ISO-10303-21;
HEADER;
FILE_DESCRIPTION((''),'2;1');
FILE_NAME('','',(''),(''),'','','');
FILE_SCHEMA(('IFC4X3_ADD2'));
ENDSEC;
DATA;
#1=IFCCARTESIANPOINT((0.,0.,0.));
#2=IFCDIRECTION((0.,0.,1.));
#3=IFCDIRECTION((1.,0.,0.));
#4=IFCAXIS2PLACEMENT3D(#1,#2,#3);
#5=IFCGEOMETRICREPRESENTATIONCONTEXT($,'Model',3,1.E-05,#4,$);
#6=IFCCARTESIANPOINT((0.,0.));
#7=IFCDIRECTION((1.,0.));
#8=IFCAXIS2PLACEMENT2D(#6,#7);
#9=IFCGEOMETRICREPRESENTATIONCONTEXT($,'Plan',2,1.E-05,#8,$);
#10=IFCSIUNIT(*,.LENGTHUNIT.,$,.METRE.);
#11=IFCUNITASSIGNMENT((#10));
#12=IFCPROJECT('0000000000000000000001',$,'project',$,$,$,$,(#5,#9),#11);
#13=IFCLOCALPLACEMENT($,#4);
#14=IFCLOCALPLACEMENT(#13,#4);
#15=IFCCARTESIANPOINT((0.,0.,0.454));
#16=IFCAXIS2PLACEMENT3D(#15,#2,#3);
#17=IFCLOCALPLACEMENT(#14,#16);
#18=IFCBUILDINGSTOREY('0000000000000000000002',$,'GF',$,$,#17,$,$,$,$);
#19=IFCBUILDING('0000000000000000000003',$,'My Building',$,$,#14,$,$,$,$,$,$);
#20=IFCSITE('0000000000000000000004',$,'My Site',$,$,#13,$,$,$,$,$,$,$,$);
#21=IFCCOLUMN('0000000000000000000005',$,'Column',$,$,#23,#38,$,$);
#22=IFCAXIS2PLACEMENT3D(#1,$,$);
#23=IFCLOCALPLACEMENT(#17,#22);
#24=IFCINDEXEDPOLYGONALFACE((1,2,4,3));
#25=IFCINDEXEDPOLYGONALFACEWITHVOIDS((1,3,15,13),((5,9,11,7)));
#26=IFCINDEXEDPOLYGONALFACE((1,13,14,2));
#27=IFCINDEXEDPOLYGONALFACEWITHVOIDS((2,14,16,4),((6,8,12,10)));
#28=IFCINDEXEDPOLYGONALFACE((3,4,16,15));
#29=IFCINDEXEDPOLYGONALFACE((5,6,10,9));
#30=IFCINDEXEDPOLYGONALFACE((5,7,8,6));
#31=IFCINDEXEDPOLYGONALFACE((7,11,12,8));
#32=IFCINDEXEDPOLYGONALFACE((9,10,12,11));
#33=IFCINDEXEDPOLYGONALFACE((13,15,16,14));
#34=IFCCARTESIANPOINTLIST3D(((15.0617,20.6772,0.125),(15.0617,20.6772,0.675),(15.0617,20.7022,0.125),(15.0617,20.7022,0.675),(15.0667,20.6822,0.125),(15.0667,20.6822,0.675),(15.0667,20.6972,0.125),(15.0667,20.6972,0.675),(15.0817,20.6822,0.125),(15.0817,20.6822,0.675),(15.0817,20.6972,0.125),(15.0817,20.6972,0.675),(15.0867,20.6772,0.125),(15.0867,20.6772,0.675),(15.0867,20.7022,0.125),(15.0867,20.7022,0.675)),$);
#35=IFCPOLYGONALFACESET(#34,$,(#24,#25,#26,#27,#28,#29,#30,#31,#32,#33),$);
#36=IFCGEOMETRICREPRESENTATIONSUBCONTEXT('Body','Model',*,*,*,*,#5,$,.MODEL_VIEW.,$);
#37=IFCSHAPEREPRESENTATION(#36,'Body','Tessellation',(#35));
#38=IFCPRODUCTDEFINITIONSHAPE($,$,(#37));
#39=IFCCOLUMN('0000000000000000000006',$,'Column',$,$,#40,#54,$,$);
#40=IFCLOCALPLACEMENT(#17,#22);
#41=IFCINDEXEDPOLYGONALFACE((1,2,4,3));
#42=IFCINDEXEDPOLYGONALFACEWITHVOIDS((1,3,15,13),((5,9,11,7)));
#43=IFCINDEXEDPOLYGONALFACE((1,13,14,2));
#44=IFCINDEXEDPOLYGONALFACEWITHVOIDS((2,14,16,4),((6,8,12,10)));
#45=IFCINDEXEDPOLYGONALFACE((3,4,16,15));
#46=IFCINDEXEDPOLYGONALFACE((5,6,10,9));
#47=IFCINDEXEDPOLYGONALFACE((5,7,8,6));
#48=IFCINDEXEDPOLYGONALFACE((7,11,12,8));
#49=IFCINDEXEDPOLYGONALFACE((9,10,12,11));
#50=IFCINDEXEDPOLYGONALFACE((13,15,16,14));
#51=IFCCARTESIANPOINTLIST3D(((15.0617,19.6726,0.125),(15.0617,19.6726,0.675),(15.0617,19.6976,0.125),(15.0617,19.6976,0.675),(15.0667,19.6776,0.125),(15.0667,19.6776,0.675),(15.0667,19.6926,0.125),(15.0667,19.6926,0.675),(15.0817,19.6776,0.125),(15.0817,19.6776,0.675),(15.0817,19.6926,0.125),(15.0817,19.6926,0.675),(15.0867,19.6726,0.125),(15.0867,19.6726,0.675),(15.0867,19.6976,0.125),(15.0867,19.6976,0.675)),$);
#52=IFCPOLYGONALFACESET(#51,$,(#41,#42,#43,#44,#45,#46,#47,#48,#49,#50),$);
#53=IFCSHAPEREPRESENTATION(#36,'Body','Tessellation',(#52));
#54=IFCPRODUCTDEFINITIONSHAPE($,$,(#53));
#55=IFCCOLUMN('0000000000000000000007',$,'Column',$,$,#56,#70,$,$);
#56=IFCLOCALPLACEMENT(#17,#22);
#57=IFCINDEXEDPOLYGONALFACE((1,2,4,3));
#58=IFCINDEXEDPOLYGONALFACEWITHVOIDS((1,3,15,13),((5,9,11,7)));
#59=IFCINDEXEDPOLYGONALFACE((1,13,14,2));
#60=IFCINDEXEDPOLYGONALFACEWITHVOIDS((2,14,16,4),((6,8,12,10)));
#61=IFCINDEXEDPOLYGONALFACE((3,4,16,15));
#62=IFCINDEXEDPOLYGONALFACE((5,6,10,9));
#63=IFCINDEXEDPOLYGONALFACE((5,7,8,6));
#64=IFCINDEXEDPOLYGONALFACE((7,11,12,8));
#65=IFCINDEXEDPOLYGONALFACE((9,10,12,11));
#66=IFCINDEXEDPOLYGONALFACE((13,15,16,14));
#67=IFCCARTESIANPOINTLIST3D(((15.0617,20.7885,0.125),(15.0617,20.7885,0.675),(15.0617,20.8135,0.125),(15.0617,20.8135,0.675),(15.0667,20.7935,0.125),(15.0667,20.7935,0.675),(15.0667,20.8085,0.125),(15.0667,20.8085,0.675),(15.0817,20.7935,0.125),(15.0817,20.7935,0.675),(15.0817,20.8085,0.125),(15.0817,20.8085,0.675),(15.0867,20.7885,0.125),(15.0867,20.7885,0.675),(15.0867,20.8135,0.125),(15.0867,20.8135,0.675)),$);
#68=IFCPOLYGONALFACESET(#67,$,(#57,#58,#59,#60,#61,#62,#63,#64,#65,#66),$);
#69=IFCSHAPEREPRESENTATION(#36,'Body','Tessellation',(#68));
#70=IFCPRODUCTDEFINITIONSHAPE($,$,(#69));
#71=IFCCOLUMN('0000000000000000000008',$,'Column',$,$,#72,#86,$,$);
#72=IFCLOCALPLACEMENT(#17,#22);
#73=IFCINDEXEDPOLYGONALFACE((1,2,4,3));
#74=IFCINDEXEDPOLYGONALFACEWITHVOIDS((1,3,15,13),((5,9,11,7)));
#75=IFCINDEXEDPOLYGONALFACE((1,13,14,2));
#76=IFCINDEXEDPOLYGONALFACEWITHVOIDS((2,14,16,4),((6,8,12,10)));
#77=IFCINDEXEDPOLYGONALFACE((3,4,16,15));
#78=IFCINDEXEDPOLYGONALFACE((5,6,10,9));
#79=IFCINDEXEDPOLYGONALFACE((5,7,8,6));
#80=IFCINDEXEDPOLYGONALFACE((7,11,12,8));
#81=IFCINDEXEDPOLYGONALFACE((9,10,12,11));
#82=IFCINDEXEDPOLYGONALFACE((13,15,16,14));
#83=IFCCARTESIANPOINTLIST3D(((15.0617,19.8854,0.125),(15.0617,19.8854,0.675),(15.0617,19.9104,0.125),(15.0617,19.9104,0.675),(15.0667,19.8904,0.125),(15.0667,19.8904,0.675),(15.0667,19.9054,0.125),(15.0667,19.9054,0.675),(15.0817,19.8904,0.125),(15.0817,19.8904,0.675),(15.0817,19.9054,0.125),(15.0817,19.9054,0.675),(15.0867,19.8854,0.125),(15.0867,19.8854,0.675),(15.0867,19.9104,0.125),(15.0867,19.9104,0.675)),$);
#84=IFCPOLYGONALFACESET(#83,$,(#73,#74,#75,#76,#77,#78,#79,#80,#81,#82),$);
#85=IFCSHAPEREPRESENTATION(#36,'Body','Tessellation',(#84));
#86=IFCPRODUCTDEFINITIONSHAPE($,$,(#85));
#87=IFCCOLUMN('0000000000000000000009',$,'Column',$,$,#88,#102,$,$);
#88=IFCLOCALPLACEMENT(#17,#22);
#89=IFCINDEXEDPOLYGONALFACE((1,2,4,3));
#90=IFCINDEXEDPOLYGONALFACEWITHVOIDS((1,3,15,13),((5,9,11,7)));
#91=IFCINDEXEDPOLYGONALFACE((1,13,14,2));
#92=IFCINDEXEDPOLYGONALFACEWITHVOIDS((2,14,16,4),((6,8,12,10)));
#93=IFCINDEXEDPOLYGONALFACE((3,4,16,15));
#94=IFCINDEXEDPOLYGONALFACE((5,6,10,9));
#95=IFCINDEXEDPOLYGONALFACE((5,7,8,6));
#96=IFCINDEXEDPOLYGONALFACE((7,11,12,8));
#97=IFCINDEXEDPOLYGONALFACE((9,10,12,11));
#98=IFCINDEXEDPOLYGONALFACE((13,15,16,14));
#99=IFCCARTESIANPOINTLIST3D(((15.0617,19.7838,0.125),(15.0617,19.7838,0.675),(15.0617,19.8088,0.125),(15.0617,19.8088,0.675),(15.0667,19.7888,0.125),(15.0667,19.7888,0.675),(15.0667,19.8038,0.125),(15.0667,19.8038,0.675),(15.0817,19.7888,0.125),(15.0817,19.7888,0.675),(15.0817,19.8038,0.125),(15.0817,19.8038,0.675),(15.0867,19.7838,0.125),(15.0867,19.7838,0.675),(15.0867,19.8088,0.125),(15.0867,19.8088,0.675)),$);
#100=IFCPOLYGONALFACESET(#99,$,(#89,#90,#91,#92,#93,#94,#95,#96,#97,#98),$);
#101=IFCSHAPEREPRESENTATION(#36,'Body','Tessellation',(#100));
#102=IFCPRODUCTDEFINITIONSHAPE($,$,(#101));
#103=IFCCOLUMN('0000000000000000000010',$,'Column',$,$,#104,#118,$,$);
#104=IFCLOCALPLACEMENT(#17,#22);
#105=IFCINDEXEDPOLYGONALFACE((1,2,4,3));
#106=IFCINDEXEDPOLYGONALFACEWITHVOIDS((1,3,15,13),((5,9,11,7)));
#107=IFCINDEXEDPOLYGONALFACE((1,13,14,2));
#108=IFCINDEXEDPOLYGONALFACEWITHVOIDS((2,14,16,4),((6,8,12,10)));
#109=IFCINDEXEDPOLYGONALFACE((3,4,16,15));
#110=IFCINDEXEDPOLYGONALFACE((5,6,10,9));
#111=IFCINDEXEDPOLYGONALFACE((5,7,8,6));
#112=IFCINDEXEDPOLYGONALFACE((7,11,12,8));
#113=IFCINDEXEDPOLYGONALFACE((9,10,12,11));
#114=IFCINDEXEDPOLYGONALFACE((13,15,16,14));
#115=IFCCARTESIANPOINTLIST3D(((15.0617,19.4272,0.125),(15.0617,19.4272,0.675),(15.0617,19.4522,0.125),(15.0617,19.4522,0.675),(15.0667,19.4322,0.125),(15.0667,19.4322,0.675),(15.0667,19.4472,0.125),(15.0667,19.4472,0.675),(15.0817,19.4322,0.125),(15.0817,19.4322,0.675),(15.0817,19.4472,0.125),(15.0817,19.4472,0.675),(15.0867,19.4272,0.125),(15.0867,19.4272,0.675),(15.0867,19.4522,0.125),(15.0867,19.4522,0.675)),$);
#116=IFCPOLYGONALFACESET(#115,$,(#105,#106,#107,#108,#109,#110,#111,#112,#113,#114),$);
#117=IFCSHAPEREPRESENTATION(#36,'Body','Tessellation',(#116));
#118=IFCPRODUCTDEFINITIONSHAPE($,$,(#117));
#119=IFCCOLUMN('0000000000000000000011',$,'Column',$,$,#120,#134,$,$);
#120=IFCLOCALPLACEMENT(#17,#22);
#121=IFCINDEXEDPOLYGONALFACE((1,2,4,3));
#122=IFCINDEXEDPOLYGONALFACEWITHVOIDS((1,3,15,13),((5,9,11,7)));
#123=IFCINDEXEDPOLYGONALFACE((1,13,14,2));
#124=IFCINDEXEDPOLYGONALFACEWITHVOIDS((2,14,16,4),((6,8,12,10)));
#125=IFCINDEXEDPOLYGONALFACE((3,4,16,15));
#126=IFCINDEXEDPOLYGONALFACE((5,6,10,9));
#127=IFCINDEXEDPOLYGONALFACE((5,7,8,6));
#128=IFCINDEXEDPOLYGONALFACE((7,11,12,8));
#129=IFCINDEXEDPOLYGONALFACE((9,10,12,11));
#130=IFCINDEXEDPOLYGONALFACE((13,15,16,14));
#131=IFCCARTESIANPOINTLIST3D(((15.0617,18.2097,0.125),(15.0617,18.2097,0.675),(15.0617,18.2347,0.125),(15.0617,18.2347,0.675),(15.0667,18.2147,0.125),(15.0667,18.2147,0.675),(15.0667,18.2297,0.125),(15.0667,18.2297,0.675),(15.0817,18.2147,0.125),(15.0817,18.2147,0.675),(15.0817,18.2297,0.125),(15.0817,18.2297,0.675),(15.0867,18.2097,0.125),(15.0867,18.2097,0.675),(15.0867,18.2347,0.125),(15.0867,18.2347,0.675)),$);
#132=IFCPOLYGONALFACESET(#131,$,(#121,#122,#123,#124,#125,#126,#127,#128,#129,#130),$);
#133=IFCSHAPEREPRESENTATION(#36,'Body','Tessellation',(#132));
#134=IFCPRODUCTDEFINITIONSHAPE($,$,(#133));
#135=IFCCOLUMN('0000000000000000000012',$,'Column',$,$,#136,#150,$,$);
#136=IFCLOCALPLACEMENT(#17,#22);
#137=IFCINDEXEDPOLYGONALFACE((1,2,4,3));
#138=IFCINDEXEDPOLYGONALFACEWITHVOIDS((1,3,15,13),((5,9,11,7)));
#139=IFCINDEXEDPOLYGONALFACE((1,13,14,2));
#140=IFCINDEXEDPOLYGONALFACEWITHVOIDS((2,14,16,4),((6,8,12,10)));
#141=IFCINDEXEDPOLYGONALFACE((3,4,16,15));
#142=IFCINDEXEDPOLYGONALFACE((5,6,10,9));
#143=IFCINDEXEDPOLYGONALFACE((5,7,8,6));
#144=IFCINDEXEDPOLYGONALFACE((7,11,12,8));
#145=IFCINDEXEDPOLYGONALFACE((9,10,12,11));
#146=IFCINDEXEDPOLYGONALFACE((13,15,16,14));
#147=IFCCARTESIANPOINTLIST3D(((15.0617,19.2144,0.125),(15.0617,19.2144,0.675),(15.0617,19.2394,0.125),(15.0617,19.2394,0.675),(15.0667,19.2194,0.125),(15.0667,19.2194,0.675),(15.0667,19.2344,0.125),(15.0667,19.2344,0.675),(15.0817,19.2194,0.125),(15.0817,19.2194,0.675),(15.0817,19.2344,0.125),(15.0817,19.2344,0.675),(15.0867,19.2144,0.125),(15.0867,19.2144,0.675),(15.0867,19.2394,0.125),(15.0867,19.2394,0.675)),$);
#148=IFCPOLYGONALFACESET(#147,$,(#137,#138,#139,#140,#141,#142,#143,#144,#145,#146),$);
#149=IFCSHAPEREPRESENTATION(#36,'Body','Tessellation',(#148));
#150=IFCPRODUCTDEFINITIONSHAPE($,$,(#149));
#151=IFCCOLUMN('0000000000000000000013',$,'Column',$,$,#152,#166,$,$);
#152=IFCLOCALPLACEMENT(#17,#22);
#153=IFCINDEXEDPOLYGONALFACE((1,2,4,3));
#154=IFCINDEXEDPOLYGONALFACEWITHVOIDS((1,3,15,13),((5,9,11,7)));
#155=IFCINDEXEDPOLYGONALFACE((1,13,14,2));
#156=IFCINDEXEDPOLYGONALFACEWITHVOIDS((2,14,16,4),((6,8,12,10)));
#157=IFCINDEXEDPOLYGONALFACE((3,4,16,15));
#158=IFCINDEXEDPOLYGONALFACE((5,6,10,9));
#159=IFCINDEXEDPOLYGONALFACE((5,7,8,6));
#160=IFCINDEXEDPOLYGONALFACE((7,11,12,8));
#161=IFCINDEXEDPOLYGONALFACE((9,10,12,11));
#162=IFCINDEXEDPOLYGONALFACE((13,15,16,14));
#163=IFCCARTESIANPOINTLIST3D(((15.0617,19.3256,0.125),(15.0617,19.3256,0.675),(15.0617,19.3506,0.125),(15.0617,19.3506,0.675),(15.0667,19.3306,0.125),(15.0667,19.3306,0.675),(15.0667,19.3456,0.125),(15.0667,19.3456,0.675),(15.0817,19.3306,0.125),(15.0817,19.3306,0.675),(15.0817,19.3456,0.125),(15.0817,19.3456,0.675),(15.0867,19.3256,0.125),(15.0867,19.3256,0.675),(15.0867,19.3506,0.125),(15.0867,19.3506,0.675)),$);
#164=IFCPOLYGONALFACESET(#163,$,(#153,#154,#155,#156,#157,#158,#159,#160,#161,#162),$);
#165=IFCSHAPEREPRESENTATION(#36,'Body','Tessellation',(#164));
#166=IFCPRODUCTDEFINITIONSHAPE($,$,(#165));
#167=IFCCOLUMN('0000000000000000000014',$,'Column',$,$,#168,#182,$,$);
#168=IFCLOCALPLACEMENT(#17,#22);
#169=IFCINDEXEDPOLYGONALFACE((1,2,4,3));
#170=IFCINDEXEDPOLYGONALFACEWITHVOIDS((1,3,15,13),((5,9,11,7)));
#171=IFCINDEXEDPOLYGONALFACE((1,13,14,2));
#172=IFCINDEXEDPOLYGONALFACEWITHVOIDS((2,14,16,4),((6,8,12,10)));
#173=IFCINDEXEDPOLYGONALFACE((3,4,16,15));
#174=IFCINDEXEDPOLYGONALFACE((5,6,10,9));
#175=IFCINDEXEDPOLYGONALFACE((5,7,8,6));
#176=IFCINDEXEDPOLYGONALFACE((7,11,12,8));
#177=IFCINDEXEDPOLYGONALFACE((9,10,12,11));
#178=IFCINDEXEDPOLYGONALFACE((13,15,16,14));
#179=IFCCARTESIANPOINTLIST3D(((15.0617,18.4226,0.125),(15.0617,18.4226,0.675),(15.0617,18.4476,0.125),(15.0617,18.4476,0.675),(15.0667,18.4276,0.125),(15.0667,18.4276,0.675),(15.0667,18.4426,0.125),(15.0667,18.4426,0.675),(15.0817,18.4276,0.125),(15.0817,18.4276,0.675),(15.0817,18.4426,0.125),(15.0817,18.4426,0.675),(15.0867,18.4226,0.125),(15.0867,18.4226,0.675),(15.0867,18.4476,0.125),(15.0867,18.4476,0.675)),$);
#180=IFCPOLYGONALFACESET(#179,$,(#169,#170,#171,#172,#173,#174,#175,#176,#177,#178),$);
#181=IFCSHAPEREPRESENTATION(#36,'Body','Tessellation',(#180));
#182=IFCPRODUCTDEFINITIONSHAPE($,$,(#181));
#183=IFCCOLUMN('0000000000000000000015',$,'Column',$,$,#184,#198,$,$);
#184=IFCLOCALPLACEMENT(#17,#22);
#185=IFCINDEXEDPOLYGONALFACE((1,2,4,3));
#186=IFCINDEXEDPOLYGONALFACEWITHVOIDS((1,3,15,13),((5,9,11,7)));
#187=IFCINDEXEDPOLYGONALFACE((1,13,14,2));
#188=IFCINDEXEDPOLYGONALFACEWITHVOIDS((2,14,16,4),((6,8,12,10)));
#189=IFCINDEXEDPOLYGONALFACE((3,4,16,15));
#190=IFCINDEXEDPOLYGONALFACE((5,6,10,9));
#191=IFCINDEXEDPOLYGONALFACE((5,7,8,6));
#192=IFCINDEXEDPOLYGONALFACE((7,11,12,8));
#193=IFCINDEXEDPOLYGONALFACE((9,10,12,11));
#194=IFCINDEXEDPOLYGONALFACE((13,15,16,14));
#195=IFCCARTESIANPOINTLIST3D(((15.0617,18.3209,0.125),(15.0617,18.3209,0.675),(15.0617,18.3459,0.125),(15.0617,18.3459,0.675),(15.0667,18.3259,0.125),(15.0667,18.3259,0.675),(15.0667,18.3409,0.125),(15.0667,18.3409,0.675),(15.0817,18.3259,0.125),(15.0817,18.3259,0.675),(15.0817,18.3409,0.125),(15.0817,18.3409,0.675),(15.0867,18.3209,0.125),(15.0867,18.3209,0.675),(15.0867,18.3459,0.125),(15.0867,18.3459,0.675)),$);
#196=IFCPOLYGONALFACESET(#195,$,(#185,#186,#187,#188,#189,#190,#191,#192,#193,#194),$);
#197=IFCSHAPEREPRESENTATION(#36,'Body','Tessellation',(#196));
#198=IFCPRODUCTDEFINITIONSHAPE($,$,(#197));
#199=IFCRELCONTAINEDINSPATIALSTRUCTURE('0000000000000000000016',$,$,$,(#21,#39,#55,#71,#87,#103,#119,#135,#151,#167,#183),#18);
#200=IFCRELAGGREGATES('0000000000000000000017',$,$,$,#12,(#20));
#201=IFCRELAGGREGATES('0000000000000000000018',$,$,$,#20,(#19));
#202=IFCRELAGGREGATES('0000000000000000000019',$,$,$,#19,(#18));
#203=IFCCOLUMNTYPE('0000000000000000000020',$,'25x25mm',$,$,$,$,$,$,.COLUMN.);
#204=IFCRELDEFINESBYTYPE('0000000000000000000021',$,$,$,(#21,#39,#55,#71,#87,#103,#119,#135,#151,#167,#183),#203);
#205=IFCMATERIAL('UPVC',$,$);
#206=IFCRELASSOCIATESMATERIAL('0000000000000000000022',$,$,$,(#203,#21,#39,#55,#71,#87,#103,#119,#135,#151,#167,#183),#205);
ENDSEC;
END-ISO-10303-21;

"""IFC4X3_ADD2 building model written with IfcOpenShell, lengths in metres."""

from ifc_helpers import new_model, si_unit, frame, origin_with_axes, origin_2d_with_axis, place, context, subcontext, project, spatial, hollow_rectangle, extrude, material, material_profile, profile_set, profile_usage, type_object, element, save


model = new_model("IFC4X3_ADD2")

# Units and contexts
model_context = context("Model", 3, precision=1e-05, world=origin_with_axes())
plan_context = context("Plan", 2, precision=1e-05, world=origin_2d_with_axis())
body_context = subcontext(model_context, "Body", "Model", "MODEL_VIEW")
ifc_project = project(units=[si_unit("LENGTHUNIT", "METRE")], contexts=[model_context, plan_context])

# Site, building, storey
site_placement = place(None, origin_with_axes())
site = spatial("IfcSite", under=ifc_project, at=site_placement, Name="My Site")
building_placement = place(site_placement, origin_with_axes())
building = spatial("IfcBuilding", under=site, at=building_placement, Name="My Building")
storey_placement = place(building_placement, frame((0.0, 0.0, 0.454), z_axis=(0.0, 0.0, 1.0), x_axis=(1.0, 0.0, 0.0)))
storey = spatial("IfcBuildingStorey", under=building, at=storey_placement, Name="GF")

# Columns
ifc_material_1 = material(Name="UPVC")
ifc_material_profile_1 = material_profile(ifc_material_1, hollow_rectangle(XDim=0.025, YDim=0.025, WallThickness=0.005))
ifc_profile_set_1 = profile_set([ifc_material_profile_1])
ifc_profile_usage_1 = profile_usage(ifc_profile_set_1)
column_type_1 = type_object("IfcColumnType", Name="25x25mm", PredefinedType="COLUMN", material=ifc_profile_set_1)
column_1_placement = place(storey_placement, frame((15.0742, 20.6897, 0.125), z_axis=(0.0, 0.0, 1.0), x_axis=(0.0, -1.0, 0.0)))
element("IfcColumn", 1, at=column_1_placement, inside=storey, type_object=column_type_1, material=ifc_profile_usage_1, Name="Column", context=body_context, shape_type="SweptSolid", body=[
    extrude(hollow_rectangle(XDim=0.025, YDim=0.025, WallThickness=0.005), origin_with_axes(), (0.0, 0.0, 1.0), 0.55),
])
ifc_profile_usage_2 = profile_usage(ifc_profile_set_1)
column_2_placement = place(storey_placement, frame((15.0742, 19.6851, 0.125), z_axis=(0.0, 0.0, 1.0), x_axis=(0.0, -1.0, 0.0)))
element("IfcColumn", 2, at=column_2_placement, inside=storey, type_object=column_type_1, material=ifc_profile_usage_2, Name="Column", context=body_context, shape_type="SweptSolid", body=[
    extrude(hollow_rectangle(XDim=0.025, YDim=0.025, WallThickness=0.005), origin_with_axes(), (0.0, 0.0, 1.0), 0.55),
])
ifc_profile_usage_3 = profile_usage(ifc_profile_set_1)
column_3_placement = place(storey_placement, frame((15.0742, 20.801, 0.125), z_axis=(0.0, 0.0, 1.0), x_axis=(0.0, -1.0, 0.0)))
element("IfcColumn", 3, at=column_3_placement, inside=storey, type_object=column_type_1, material=ifc_profile_usage_3, Name="Column", context=body_context, shape_type="SweptSolid", body=[
    extrude(hollow_rectangle(XDim=0.025, YDim=0.025, WallThickness=0.005), origin_with_axes(), (0.0, 0.0, 1.0), 0.55),
])
ifc_profile_usage_4 = profile_usage(ifc_profile_set_1)
column_4_placement = place(storey_placement, frame((15.0742, 19.8979, 0.125), z_axis=(0.0, 0.0, 1.0), x_axis=(0.0, -1.0, 0.0)))
element("IfcColumn", 4, at=column_4_placement, inside=storey, type_object=column_type_1, material=ifc_profile_usage_4, Name="Column", context=body_context, shape_type="SweptSolid", body=[
    extrude(hollow_rectangle(XDim=0.025, YDim=0.025, WallThickness=0.005), origin_with_axes(), (0.0, 0.0, 1.0), 0.55),
])
ifc_profile_usage_5 = profile_usage(ifc_profile_set_1)
column_5_placement = place(storey_placement, frame((15.0742, 19.7963, 0.125), z_axis=(0.0, 0.0, 1.0), x_axis=(0.0, -1.0, 0.0)))
element("IfcColumn", 5, at=column_5_placement, inside=storey, type_object=column_type_1, material=ifc_profile_usage_5, Name="Column", context=body_context, shape_type="SweptSolid", body=[
    extrude(hollow_rectangle(XDim=0.025, YDim=0.025, WallThickness=0.005), origin_with_axes(), (0.0, 0.0, 1.0), 0.55),
])
ifc_profile_usage_6 = profile_usage(ifc_profile_set_1)
column_6_placement = place(storey_placement, frame((15.0742, 19.4397, 0.125), z_axis=(0.0, 0.0, 1.0), x_axis=(0.0, -1.0, 0.0)))
element("IfcColumn", 6, at=column_6_placement, inside=storey, type_object=column_type_1, material=ifc_profile_usage_6, Name="Column", context=body_context, shape_type="SweptSolid", body=[
    extrude(hollow_rectangle(XDim=0.025, YDim=0.025, WallThickness=0.005), origin_with_axes(), (0.0, 0.0, 1.0), 0.55),
])
ifc_profile_usage_7 = profile_usage(ifc_profile_set_1)
column_7_placement = place(storey_placement, frame((15.0742, 18.2222, 0.125), z_axis=(0.0, 0.0, 1.0), x_axis=(0.0, -1.0, 0.0)))
element("IfcColumn", 7, at=column_7_placement, inside=storey, type_object=column_type_1, material=ifc_profile_usage_7, Name="Column", context=body_context, shape_type="SweptSolid", body=[
    extrude(hollow_rectangle(XDim=0.025, YDim=0.025, WallThickness=0.005), origin_with_axes(), (0.0, 0.0, 1.0), 0.55),
])
ifc_profile_usage_8 = profile_usage(ifc_profile_set_1)
column_8_placement = place(storey_placement, frame((15.0742, 19.2269, 0.125), z_axis=(0.0, 0.0, 1.0), x_axis=(0.0, -1.0, 0.0)))
element("IfcColumn", 8, at=column_8_placement, inside=storey, type_object=column_type_1, material=ifc_profile_usage_8, Name="Column", context=body_context, shape_type="SweptSolid", body=[
    extrude(hollow_rectangle(XDim=0.025, YDim=0.025, WallThickness=0.005), origin_with_axes(), (0.0, 0.0, 1.0), 0.55),
])
ifc_profile_usage_9 = profile_usage(ifc_profile_set_1)
column_9_placement = place(storey_placement, frame((15.0742, 19.3381, 0.125), z_axis=(0.0, 0.0, 1.0), x_axis=(0.0, -1.0, 0.0)))
element("IfcColumn", 9, at=column_9_placement, inside=storey, type_object=column_type_1, material=ifc_profile_usage_9, Name="Column", context=body_context, shape_type="SweptSolid", body=[
    extrude(hollow_rectangle(XDim=0.025, YDim=0.025, WallThickness=0.005), origin_with_axes(), (0.0, 0.0, 1.0), 0.55),
])
ifc_profile_usage_10 = profile_usage(ifc_profile_set_1)
column_10_placement = place(storey_placement, frame((15.0742, 18.4351, 0.125), z_axis=(0.0, 0.0, 1.0), x_axis=(0.0, -1.0, 0.0)))
element("IfcColumn", 10, at=column_10_placement, inside=storey, type_object=column_type_1, material=ifc_profile_usage_10, Name="Column", context=body_context, shape_type="SweptSolid", body=[
    extrude(hollow_rectangle(XDim=0.025, YDim=0.025, WallThickness=0.005), origin_with_axes(), (0.0, 0.0, 1.0), 0.55),
])
ifc_profile_usage_11 = profile_usage(ifc_profile_set_1)
column_11_placement = place(storey_placement, frame((15.0742, 18.3334, 0.125), z_axis=(0.0, 0.0, 1.0), x_axis=(0.0, -1.0, 0.0)))
element("IfcColumn", 11, at=column_11_placement, inside=storey, type_object=column_type_1, material=ifc_profile_usage_11, Name="Column", context=body_context, shape_type="SweptSolid", body=[
    extrude(hollow_rectangle(XDim=0.025, YDim=0.025, WallThickness=0.005), origin_with_axes(), (0.0, 0.0, 1.0), 0.55),
])

save(model, "model.ifc")
